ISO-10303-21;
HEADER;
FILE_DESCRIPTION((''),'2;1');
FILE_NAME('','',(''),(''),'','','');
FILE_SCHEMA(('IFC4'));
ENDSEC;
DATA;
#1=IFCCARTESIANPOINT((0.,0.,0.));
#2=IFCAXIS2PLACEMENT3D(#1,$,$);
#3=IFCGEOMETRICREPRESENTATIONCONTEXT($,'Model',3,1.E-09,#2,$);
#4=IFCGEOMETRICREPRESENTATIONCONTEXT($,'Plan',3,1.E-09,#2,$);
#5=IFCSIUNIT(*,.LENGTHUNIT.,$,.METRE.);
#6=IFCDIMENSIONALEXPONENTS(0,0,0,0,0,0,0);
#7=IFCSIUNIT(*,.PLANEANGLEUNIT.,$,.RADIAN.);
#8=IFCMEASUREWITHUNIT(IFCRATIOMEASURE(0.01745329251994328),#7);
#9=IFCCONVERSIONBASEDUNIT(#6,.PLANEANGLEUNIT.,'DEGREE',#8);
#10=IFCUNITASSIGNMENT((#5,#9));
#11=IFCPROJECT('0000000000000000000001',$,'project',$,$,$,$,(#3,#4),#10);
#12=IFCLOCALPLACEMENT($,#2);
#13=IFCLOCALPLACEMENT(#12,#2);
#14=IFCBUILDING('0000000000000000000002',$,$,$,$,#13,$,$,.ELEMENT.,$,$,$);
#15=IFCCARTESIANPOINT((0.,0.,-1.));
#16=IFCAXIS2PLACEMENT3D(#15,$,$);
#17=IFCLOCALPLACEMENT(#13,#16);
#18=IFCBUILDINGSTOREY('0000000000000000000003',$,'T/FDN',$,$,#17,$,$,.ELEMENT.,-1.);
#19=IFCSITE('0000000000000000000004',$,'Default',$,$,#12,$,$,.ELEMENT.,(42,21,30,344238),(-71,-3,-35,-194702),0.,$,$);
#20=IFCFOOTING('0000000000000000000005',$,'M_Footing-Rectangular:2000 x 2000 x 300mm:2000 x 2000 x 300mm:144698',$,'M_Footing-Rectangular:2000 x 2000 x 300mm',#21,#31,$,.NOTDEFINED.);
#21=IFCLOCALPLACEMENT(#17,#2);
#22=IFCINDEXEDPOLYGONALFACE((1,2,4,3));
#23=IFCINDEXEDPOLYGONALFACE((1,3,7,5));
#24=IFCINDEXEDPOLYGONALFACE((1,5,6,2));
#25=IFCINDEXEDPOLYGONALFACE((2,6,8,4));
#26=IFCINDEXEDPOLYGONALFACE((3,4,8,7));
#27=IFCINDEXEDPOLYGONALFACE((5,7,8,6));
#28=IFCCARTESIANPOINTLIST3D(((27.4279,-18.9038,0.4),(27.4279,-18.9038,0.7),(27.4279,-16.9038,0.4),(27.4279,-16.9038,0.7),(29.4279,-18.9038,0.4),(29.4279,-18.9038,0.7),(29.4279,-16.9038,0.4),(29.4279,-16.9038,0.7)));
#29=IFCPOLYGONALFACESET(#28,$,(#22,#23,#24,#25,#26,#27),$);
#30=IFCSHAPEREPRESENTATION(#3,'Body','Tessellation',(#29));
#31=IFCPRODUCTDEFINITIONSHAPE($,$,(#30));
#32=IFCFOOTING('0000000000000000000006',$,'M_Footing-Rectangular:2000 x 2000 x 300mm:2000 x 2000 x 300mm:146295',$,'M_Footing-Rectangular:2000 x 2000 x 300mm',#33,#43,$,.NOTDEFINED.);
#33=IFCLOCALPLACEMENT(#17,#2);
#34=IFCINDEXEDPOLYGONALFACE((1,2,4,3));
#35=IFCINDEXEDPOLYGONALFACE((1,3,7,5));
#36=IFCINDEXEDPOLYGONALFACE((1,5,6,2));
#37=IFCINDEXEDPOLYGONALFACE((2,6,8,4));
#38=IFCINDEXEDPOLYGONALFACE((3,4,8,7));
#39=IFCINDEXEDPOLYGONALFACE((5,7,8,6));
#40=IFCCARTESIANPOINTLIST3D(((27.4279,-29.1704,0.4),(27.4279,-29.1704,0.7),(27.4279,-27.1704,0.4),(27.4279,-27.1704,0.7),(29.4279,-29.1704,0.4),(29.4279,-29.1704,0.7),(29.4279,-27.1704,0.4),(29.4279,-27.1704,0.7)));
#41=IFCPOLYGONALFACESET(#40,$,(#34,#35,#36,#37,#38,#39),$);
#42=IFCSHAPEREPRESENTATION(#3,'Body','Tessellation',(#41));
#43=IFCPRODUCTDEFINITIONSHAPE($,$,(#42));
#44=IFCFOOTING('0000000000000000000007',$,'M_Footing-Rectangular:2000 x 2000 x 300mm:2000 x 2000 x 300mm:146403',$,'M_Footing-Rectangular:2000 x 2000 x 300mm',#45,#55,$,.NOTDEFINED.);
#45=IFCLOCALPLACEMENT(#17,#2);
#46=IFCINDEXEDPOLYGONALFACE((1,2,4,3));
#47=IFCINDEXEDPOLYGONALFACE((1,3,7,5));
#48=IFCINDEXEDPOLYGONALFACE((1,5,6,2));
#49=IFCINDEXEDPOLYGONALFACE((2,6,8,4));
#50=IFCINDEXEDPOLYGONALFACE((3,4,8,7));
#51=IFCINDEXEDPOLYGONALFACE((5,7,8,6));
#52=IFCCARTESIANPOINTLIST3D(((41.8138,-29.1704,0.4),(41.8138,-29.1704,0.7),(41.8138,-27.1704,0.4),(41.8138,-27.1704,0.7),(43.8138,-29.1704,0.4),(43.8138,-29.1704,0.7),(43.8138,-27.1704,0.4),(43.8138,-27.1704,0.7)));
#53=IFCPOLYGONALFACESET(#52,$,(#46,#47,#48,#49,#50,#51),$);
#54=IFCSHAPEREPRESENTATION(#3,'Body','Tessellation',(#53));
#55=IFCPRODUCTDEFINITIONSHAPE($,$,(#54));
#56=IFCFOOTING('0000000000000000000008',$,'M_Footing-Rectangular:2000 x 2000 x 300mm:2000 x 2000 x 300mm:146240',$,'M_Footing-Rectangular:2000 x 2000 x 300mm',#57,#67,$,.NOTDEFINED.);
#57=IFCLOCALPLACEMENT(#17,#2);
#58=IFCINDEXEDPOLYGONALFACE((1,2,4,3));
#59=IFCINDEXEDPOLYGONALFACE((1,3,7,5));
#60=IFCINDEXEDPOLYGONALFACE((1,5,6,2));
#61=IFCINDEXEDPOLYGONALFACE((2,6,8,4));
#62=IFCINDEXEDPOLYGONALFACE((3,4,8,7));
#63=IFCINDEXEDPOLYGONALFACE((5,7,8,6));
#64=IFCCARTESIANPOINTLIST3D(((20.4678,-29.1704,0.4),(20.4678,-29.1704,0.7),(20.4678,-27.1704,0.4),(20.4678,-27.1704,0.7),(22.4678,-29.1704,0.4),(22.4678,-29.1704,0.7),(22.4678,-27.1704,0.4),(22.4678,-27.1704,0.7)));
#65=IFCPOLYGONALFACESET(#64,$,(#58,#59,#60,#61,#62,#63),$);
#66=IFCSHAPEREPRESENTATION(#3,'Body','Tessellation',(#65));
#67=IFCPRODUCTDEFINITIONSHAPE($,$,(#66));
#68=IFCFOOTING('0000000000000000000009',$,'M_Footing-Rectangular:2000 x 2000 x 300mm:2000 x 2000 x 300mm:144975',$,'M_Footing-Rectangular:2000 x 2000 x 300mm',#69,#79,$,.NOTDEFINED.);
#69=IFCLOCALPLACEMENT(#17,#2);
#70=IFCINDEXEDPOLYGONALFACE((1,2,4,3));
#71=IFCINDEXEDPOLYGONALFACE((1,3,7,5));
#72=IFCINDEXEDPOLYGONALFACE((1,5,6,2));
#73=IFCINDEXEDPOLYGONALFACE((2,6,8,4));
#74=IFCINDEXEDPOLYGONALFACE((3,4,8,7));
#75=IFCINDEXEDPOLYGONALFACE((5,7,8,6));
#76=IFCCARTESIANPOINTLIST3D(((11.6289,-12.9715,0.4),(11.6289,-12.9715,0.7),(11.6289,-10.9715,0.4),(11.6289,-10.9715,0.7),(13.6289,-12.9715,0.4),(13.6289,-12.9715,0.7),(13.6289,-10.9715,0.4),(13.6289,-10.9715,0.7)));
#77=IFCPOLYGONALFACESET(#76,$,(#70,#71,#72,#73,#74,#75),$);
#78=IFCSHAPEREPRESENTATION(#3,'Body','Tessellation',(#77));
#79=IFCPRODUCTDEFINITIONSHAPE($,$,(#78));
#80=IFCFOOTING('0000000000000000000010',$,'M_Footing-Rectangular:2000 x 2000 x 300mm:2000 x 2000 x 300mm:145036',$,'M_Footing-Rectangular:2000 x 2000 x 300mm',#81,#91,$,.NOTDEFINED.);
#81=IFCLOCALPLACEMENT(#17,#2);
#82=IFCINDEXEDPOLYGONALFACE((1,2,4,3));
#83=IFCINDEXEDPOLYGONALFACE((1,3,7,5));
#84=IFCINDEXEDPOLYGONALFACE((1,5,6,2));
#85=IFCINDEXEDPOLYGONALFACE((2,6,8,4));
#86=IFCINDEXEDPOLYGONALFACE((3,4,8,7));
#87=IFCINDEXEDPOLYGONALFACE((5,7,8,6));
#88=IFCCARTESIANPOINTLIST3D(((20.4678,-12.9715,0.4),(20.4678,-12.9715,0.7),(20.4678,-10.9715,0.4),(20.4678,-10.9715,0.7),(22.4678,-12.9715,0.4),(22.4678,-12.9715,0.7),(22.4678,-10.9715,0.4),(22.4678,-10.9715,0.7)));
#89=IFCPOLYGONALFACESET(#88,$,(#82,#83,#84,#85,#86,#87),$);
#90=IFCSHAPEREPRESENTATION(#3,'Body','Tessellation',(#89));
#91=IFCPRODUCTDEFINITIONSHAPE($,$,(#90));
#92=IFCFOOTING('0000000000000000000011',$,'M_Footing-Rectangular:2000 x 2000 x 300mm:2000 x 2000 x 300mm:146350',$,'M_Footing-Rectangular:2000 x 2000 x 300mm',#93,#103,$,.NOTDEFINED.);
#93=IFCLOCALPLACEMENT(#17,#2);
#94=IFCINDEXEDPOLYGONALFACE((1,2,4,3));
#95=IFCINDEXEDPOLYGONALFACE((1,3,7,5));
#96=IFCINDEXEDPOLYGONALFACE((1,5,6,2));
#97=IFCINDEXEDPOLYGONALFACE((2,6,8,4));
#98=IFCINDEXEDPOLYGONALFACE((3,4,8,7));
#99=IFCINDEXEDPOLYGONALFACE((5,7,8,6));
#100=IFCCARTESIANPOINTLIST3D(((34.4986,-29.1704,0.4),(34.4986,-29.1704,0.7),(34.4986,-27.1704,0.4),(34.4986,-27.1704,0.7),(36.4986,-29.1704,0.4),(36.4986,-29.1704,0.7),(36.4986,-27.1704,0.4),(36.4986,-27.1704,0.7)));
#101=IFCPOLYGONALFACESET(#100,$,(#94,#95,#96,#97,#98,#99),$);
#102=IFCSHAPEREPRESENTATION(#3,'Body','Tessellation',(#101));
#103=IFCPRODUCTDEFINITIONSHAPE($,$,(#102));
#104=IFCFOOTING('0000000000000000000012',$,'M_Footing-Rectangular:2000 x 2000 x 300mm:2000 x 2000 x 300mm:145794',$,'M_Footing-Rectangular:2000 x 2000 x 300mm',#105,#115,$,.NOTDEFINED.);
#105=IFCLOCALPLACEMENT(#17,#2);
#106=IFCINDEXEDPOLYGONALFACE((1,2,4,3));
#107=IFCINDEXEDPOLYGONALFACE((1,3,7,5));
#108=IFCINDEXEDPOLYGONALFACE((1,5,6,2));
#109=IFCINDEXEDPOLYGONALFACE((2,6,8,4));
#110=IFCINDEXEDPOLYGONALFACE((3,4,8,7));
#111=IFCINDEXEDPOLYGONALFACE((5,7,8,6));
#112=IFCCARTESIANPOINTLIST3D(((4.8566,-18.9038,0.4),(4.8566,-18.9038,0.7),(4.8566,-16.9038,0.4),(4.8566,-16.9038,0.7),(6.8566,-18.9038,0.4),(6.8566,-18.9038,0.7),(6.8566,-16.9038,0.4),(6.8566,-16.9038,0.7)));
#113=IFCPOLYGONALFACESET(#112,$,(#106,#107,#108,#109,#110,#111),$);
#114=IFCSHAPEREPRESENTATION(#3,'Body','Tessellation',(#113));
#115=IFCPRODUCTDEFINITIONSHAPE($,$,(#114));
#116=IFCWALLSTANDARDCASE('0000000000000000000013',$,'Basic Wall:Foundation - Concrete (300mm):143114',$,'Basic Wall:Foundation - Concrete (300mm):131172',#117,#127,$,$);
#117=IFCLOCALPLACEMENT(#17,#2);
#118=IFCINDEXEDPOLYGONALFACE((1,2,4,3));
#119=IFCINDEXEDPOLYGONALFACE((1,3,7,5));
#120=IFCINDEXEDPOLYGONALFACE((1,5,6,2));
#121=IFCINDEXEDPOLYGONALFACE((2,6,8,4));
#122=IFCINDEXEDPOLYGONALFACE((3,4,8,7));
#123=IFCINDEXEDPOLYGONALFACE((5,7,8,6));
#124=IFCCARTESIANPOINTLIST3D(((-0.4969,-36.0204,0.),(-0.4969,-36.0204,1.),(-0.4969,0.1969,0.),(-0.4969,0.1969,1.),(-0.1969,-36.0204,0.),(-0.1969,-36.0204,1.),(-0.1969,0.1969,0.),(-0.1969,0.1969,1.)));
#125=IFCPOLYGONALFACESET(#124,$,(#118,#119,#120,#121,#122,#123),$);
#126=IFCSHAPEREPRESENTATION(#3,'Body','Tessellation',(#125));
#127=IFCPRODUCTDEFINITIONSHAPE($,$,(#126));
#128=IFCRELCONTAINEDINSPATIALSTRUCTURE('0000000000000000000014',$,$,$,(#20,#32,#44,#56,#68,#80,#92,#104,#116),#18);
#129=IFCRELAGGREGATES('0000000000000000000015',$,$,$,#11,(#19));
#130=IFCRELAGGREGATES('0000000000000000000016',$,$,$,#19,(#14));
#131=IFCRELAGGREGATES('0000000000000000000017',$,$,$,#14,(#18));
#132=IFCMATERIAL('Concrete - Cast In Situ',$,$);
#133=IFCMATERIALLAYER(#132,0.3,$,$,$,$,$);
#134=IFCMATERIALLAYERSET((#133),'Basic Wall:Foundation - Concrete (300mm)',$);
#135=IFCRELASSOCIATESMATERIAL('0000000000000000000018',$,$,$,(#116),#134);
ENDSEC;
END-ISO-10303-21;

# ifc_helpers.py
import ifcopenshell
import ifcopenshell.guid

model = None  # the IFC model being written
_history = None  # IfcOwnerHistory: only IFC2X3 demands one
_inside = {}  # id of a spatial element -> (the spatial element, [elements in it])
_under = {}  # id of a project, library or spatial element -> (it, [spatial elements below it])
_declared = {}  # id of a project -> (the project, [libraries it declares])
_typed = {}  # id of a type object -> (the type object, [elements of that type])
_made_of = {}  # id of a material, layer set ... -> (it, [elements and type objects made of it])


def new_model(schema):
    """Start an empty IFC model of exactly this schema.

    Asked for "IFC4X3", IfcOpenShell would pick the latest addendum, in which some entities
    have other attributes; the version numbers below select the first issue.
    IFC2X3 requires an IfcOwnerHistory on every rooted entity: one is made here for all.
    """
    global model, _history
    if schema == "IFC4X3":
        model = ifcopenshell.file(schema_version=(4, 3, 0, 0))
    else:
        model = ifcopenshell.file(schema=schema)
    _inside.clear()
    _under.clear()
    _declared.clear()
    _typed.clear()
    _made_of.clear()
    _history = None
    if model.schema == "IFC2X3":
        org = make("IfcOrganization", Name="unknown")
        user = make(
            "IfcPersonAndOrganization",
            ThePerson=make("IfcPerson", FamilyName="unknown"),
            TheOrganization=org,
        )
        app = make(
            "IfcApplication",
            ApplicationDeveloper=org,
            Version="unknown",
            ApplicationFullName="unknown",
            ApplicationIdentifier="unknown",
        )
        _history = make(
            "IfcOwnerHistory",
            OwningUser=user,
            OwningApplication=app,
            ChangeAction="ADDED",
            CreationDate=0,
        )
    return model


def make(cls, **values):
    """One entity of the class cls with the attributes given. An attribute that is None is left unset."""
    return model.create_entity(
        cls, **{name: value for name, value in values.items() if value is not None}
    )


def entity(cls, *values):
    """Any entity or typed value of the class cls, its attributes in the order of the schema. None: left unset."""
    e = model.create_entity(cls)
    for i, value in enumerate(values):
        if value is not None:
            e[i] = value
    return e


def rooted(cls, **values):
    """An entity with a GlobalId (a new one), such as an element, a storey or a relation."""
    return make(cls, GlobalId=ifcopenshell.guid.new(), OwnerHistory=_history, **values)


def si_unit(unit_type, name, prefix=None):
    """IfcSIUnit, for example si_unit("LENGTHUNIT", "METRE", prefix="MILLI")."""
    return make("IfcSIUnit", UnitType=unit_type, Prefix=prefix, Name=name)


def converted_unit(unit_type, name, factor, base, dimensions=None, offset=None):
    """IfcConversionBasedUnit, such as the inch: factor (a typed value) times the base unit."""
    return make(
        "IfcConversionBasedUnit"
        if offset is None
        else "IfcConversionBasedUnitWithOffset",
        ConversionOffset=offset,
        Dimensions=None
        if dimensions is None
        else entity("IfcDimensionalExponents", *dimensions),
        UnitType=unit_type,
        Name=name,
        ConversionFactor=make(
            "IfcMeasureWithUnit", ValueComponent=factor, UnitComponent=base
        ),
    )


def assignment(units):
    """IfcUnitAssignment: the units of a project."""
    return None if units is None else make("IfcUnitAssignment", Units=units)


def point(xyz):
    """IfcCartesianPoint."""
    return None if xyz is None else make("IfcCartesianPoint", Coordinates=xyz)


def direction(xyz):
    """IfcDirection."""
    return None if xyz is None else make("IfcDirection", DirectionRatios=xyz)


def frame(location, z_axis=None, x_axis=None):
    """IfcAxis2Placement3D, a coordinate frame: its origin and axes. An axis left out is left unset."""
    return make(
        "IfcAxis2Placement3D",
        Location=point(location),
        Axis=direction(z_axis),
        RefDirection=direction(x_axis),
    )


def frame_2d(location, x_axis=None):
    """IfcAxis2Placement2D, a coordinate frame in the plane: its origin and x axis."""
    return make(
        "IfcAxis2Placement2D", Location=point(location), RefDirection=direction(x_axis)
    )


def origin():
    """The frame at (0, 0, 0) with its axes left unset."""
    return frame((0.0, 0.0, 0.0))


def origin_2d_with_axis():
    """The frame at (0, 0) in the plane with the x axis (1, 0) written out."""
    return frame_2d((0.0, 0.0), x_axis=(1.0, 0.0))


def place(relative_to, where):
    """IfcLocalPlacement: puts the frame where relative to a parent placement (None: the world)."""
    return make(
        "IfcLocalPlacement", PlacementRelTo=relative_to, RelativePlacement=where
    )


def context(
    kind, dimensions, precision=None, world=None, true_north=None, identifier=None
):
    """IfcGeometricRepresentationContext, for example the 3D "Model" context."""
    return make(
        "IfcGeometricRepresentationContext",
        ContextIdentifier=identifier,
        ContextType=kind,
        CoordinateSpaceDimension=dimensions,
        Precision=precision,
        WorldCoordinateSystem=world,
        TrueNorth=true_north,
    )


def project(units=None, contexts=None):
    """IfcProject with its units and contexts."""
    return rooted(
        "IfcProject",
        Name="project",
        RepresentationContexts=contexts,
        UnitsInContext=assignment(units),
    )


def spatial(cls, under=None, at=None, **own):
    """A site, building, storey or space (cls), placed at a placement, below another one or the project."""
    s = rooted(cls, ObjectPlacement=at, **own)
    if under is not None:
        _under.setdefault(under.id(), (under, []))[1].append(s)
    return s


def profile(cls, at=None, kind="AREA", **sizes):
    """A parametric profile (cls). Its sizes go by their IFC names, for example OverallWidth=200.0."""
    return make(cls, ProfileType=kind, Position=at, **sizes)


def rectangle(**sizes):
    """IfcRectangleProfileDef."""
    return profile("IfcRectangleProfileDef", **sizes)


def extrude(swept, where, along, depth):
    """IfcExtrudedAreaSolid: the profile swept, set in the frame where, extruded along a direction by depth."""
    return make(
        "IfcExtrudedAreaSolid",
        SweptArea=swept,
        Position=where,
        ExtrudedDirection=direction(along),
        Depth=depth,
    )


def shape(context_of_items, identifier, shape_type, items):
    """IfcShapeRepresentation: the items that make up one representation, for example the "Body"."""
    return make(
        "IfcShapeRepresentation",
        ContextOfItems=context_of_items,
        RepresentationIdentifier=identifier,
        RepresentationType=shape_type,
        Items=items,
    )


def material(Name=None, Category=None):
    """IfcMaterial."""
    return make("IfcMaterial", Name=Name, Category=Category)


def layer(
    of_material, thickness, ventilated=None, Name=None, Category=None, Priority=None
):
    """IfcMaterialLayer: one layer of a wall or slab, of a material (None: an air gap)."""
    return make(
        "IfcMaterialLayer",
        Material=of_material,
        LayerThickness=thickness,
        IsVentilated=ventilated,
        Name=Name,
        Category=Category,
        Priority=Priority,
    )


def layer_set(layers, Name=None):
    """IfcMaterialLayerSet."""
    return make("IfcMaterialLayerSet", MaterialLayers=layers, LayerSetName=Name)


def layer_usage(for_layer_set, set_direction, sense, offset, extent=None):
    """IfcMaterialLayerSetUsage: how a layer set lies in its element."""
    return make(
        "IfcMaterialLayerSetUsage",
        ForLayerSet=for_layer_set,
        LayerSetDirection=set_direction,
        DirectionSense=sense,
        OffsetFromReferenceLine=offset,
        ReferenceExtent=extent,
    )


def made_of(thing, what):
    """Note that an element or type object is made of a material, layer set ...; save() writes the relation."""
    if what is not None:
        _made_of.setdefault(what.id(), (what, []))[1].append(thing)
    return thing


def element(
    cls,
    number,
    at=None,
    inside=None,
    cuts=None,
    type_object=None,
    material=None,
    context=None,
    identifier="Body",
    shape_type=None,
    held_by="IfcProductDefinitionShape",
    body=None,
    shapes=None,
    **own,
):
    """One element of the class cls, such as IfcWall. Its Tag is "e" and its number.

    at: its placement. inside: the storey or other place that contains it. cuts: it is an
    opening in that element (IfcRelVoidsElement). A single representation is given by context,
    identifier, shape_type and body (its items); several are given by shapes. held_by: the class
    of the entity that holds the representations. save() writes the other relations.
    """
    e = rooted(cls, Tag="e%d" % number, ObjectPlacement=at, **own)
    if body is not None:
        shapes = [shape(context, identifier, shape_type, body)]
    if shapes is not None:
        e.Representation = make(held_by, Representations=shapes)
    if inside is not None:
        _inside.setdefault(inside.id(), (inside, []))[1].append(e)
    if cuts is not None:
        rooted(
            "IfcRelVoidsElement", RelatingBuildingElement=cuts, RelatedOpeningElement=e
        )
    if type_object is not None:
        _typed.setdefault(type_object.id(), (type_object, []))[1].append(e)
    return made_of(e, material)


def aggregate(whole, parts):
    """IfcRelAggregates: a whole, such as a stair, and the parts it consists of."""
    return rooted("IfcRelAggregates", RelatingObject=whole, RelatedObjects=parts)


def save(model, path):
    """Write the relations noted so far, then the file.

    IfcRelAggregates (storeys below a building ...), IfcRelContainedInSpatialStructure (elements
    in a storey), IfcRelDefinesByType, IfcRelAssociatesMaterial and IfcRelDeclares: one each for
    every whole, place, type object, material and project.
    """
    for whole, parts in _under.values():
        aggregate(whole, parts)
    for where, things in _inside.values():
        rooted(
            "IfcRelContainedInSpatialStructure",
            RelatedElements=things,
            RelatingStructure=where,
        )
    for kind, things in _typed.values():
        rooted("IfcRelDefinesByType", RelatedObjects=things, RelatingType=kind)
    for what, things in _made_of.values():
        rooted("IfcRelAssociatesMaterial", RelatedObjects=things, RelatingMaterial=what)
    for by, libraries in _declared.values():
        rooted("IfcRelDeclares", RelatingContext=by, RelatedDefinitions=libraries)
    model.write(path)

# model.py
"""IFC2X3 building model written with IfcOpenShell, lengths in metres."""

from ifc_helpers import new_model, entity, si_unit, converted_unit, frame, frame_2d, origin, origin_2d_with_axis, place, context, project, spatial, rectangle, extrude, material, layer, layer_set, layer_usage, element, save


model = new_model("IFC2X3")

# Units and contexts
model_context = context("Model", 3, precision=1e-09, world=origin())
plan_context = context("Plan", 3, precision=1e-09, world=origin())
ifc_project = project(units=[si_unit("LENGTHUNIT", "METRE"), converted_unit("PLANEANGLEUNIT", "DEGREE", entity("IfcRatioMeasure", 0.01745329251994328), si_unit("PLANEANGLEUNIT", "RADIAN"), dimensions=[0, 0, 0, 0, 0, 0, 0])], contexts=[model_context, plan_context])

# Site, building, storey
site_placement = place(None, origin())
site = spatial("IfcSite", under=ifc_project, at=site_placement, Name="Default", CompositionType="ELEMENT", RefLatitude=(42, 21, 30, 344238), RefLongitude=(-71, -3, -35, -194702), RefElevation=0.0)
building_placement = place(site_placement, origin())
building = spatial("IfcBuilding", under=site, at=building_placement, CompositionType="ELEMENT")
storey_placement = place(building_placement, frame((0.0, 0.0, -1.0)))
storey = spatial("IfcBuildingStorey", under=building, at=storey_placement, Name="T/FDN", CompositionType="ELEMENT", Elevation=-1.0)

# Footings
footing_1_placement = place(storey_placement, origin())
element("IfcFooting", 1, at=footing_1_placement, inside=storey, Name="M_Footing-Rectangular:2000 x 2000 x 300mm:2000 x 2000 x 300mm:144698", ObjectType="M_Footing-Rectangular:2000 x 2000 x 300mm", PredefinedType="NOTDEFINED", context=model_context, shape_type="SweptSolid", body=[
    extrude(rectangle(XDim=2.0, YDim=2.0, at=origin_2d_with_axis()), frame((28.4279, -17.9038, 0.4), z_axis=(0.0, 0.0, 1.0), x_axis=(-1.0, 0.0, 0.0)), (0.0, 0.0, 1.0), 0.3),
])
footing_2_placement = place(storey_placement, origin())
element("IfcFooting", 2, at=footing_2_placement, inside=storey, Name="M_Footing-Rectangular:2000 x 2000 x 300mm:2000 x 2000 x 300mm:146295", ObjectType="M_Footing-Rectangular:2000 x 2000 x 300mm", PredefinedType="NOTDEFINED", context=model_context, shape_type="SweptSolid", body=[
    extrude(rectangle(XDim=2.0, YDim=2.0, at=origin_2d_with_axis()), frame((28.4279, -28.1704, 0.4), z_axis=(0.0, 0.0, 1.0), x_axis=(-1.0, 0.0, 0.0)), (0.0, 0.0, 1.0), 0.3),
])
footing_3_placement = place(storey_placement, origin())
element("IfcFooting", 3, at=footing_3_placement, inside=storey, Name="M_Footing-Rectangular:2000 x 2000 x 300mm:2000 x 2000 x 300mm:146403", ObjectType="M_Footing-Rectangular:2000 x 2000 x 300mm", PredefinedType="NOTDEFINED", context=model_context, shape_type="SweptSolid", body=[
    extrude(rectangle(XDim=2.0, YDim=2.0, at=origin_2d_with_axis()), frame((42.8138, -28.1704, 0.4), z_axis=(0.0, 0.0, 1.0), x_axis=(-1.0, 0.0, 0.0)), (0.0, 0.0, 1.0), 0.3),
])
footing_4_placement = place(storey_placement, origin())
element("IfcFooting", 4, at=footing_4_placement, inside=storey, Name="M_Footing-Rectangular:2000 x 2000 x 300mm:2000 x 2000 x 300mm:146240", ObjectType="M_Footing-Rectangular:2000 x 2000 x 300mm", PredefinedType="NOTDEFINED", context=model_context, shape_type="SweptSolid", body=[
    extrude(rectangle(XDim=2.0, YDim=2.0, at=origin_2d_with_axis()), frame((21.4678, -28.1704, 0.4), z_axis=(0.0, 0.0, 1.0), x_axis=(-1.0, 0.0, 0.0)), (0.0, 0.0, 1.0), 0.3),
])
footing_5_placement = place(storey_placement, origin())
element("IfcFooting", 5, at=footing_5_placement, inside=storey, Name="M_Footing-Rectangular:2000 x 2000 x 300mm:2000 x 2000 x 300mm:144975", ObjectType="M_Footing-Rectangular:2000 x 2000 x 300mm", PredefinedType="NOTDEFINED", context=model_context, shape_type="SweptSolid", body=[
    extrude(rectangle(XDim=2.0, YDim=2.0, at=origin_2d_with_axis()), frame((12.6289, -11.9715, 0.4), z_axis=(0.0, 0.0, 1.0), x_axis=(-1.0, 0.0, 0.0)), (0.0, 0.0, 1.0), 0.3),
])
footing_6_placement = place(storey_placement, origin())
element("IfcFooting", 6, at=footing_6_placement, inside=storey, Name="M_Footing-Rectangular:2000 x 2000 x 300mm:2000 x 2000 x 300mm:145036", ObjectType="M_Footing-Rectangular:2000 x 2000 x 300mm", PredefinedType="NOTDEFINED", context=model_context, shape_type="SweptSolid", body=[
    extrude(rectangle(XDim=2.0, YDim=2.0, at=origin_2d_with_axis()), frame((21.4678, -11.9715, 0.4), z_axis=(0.0, 0.0, 1.0), x_axis=(-1.0, 0.0, 0.0)), (0.0, 0.0, 1.0), 0.3),
])
footing_7_placement = place(storey_placement, origin())
element("IfcFooting", 7, at=footing_7_placement, inside=storey, Name="M_Footing-Rectangular:2000 x 2000 x 300mm:2000 x 2000 x 300mm:146350", ObjectType="M_Footing-Rectangular:2000 x 2000 x 300mm", PredefinedType="NOTDEFINED", context=model_context, shape_type="SweptSolid", body=[
    extrude(rectangle(XDim=2.0, YDim=2.0, at=origin_2d_with_axis()), frame((35.4986, -28.1704, 0.4), z_axis=(0.0, 0.0, 1.0), x_axis=(-1.0, 0.0, 0.0)), (0.0, 0.0, 1.0), 0.3),
])
footing_8_placement = place(storey_placement, origin())
element("IfcFooting", 8, at=footing_8_placement, inside=storey, Name="M_Footing-Rectangular:2000 x 2000 x 300mm:2000 x 2000 x 300mm:145794", ObjectType="M_Footing-Rectangular:2000 x 2000 x 300mm", PredefinedType="NOTDEFINED", context=model_context, shape_type="SweptSolid", body=[
    extrude(rectangle(XDim=2.0, YDim=2.0, at=origin_2d_with_axis()), frame((5.8566, -17.9038, 0.4), z_axis=(0.0, 0.0, 1.0), x_axis=(-1.0, 0.0, 0.0)), (0.0, 0.0, 1.0), 0.3),
])

# Wall
ifc_material_1 = material(Name="Concrete - Cast In Situ")
ifc_layer = layer(ifc_material_1, 0.3)
ifc_layer_set = layer_set([ifc_layer], Name="Basic Wall:Foundation - Concrete (300mm)")
ifc_layer_usage = layer_usage(ifc_layer_set, "AXIS2", "NEGATIVE", 0.15)
wall_placement = place(storey_placement, frame((-0.3469, -36.0204, 0.0), z_axis=(0.0, 0.0, 1.0), x_axis=(0.0, 1.0, 0.0)))
element("IfcWallStandardCase", 9, at=wall_placement, inside=storey, material=ifc_layer_usage, Name="Basic Wall:Foundation - Concrete (300mm):143114", ObjectType="Basic Wall:Foundation - Concrete (300mm):131172", context=model_context, shape_type="SweptSolid", body=[
    extrude(rectangle(XDim=36.2173, YDim=0.3, at=frame_2d((18.1086, 0.0), x_axis=(-1.0, 0.0))), origin(), (0.0, 0.0, 1.0), 1.0),
])

save(model, "model.ifc")
